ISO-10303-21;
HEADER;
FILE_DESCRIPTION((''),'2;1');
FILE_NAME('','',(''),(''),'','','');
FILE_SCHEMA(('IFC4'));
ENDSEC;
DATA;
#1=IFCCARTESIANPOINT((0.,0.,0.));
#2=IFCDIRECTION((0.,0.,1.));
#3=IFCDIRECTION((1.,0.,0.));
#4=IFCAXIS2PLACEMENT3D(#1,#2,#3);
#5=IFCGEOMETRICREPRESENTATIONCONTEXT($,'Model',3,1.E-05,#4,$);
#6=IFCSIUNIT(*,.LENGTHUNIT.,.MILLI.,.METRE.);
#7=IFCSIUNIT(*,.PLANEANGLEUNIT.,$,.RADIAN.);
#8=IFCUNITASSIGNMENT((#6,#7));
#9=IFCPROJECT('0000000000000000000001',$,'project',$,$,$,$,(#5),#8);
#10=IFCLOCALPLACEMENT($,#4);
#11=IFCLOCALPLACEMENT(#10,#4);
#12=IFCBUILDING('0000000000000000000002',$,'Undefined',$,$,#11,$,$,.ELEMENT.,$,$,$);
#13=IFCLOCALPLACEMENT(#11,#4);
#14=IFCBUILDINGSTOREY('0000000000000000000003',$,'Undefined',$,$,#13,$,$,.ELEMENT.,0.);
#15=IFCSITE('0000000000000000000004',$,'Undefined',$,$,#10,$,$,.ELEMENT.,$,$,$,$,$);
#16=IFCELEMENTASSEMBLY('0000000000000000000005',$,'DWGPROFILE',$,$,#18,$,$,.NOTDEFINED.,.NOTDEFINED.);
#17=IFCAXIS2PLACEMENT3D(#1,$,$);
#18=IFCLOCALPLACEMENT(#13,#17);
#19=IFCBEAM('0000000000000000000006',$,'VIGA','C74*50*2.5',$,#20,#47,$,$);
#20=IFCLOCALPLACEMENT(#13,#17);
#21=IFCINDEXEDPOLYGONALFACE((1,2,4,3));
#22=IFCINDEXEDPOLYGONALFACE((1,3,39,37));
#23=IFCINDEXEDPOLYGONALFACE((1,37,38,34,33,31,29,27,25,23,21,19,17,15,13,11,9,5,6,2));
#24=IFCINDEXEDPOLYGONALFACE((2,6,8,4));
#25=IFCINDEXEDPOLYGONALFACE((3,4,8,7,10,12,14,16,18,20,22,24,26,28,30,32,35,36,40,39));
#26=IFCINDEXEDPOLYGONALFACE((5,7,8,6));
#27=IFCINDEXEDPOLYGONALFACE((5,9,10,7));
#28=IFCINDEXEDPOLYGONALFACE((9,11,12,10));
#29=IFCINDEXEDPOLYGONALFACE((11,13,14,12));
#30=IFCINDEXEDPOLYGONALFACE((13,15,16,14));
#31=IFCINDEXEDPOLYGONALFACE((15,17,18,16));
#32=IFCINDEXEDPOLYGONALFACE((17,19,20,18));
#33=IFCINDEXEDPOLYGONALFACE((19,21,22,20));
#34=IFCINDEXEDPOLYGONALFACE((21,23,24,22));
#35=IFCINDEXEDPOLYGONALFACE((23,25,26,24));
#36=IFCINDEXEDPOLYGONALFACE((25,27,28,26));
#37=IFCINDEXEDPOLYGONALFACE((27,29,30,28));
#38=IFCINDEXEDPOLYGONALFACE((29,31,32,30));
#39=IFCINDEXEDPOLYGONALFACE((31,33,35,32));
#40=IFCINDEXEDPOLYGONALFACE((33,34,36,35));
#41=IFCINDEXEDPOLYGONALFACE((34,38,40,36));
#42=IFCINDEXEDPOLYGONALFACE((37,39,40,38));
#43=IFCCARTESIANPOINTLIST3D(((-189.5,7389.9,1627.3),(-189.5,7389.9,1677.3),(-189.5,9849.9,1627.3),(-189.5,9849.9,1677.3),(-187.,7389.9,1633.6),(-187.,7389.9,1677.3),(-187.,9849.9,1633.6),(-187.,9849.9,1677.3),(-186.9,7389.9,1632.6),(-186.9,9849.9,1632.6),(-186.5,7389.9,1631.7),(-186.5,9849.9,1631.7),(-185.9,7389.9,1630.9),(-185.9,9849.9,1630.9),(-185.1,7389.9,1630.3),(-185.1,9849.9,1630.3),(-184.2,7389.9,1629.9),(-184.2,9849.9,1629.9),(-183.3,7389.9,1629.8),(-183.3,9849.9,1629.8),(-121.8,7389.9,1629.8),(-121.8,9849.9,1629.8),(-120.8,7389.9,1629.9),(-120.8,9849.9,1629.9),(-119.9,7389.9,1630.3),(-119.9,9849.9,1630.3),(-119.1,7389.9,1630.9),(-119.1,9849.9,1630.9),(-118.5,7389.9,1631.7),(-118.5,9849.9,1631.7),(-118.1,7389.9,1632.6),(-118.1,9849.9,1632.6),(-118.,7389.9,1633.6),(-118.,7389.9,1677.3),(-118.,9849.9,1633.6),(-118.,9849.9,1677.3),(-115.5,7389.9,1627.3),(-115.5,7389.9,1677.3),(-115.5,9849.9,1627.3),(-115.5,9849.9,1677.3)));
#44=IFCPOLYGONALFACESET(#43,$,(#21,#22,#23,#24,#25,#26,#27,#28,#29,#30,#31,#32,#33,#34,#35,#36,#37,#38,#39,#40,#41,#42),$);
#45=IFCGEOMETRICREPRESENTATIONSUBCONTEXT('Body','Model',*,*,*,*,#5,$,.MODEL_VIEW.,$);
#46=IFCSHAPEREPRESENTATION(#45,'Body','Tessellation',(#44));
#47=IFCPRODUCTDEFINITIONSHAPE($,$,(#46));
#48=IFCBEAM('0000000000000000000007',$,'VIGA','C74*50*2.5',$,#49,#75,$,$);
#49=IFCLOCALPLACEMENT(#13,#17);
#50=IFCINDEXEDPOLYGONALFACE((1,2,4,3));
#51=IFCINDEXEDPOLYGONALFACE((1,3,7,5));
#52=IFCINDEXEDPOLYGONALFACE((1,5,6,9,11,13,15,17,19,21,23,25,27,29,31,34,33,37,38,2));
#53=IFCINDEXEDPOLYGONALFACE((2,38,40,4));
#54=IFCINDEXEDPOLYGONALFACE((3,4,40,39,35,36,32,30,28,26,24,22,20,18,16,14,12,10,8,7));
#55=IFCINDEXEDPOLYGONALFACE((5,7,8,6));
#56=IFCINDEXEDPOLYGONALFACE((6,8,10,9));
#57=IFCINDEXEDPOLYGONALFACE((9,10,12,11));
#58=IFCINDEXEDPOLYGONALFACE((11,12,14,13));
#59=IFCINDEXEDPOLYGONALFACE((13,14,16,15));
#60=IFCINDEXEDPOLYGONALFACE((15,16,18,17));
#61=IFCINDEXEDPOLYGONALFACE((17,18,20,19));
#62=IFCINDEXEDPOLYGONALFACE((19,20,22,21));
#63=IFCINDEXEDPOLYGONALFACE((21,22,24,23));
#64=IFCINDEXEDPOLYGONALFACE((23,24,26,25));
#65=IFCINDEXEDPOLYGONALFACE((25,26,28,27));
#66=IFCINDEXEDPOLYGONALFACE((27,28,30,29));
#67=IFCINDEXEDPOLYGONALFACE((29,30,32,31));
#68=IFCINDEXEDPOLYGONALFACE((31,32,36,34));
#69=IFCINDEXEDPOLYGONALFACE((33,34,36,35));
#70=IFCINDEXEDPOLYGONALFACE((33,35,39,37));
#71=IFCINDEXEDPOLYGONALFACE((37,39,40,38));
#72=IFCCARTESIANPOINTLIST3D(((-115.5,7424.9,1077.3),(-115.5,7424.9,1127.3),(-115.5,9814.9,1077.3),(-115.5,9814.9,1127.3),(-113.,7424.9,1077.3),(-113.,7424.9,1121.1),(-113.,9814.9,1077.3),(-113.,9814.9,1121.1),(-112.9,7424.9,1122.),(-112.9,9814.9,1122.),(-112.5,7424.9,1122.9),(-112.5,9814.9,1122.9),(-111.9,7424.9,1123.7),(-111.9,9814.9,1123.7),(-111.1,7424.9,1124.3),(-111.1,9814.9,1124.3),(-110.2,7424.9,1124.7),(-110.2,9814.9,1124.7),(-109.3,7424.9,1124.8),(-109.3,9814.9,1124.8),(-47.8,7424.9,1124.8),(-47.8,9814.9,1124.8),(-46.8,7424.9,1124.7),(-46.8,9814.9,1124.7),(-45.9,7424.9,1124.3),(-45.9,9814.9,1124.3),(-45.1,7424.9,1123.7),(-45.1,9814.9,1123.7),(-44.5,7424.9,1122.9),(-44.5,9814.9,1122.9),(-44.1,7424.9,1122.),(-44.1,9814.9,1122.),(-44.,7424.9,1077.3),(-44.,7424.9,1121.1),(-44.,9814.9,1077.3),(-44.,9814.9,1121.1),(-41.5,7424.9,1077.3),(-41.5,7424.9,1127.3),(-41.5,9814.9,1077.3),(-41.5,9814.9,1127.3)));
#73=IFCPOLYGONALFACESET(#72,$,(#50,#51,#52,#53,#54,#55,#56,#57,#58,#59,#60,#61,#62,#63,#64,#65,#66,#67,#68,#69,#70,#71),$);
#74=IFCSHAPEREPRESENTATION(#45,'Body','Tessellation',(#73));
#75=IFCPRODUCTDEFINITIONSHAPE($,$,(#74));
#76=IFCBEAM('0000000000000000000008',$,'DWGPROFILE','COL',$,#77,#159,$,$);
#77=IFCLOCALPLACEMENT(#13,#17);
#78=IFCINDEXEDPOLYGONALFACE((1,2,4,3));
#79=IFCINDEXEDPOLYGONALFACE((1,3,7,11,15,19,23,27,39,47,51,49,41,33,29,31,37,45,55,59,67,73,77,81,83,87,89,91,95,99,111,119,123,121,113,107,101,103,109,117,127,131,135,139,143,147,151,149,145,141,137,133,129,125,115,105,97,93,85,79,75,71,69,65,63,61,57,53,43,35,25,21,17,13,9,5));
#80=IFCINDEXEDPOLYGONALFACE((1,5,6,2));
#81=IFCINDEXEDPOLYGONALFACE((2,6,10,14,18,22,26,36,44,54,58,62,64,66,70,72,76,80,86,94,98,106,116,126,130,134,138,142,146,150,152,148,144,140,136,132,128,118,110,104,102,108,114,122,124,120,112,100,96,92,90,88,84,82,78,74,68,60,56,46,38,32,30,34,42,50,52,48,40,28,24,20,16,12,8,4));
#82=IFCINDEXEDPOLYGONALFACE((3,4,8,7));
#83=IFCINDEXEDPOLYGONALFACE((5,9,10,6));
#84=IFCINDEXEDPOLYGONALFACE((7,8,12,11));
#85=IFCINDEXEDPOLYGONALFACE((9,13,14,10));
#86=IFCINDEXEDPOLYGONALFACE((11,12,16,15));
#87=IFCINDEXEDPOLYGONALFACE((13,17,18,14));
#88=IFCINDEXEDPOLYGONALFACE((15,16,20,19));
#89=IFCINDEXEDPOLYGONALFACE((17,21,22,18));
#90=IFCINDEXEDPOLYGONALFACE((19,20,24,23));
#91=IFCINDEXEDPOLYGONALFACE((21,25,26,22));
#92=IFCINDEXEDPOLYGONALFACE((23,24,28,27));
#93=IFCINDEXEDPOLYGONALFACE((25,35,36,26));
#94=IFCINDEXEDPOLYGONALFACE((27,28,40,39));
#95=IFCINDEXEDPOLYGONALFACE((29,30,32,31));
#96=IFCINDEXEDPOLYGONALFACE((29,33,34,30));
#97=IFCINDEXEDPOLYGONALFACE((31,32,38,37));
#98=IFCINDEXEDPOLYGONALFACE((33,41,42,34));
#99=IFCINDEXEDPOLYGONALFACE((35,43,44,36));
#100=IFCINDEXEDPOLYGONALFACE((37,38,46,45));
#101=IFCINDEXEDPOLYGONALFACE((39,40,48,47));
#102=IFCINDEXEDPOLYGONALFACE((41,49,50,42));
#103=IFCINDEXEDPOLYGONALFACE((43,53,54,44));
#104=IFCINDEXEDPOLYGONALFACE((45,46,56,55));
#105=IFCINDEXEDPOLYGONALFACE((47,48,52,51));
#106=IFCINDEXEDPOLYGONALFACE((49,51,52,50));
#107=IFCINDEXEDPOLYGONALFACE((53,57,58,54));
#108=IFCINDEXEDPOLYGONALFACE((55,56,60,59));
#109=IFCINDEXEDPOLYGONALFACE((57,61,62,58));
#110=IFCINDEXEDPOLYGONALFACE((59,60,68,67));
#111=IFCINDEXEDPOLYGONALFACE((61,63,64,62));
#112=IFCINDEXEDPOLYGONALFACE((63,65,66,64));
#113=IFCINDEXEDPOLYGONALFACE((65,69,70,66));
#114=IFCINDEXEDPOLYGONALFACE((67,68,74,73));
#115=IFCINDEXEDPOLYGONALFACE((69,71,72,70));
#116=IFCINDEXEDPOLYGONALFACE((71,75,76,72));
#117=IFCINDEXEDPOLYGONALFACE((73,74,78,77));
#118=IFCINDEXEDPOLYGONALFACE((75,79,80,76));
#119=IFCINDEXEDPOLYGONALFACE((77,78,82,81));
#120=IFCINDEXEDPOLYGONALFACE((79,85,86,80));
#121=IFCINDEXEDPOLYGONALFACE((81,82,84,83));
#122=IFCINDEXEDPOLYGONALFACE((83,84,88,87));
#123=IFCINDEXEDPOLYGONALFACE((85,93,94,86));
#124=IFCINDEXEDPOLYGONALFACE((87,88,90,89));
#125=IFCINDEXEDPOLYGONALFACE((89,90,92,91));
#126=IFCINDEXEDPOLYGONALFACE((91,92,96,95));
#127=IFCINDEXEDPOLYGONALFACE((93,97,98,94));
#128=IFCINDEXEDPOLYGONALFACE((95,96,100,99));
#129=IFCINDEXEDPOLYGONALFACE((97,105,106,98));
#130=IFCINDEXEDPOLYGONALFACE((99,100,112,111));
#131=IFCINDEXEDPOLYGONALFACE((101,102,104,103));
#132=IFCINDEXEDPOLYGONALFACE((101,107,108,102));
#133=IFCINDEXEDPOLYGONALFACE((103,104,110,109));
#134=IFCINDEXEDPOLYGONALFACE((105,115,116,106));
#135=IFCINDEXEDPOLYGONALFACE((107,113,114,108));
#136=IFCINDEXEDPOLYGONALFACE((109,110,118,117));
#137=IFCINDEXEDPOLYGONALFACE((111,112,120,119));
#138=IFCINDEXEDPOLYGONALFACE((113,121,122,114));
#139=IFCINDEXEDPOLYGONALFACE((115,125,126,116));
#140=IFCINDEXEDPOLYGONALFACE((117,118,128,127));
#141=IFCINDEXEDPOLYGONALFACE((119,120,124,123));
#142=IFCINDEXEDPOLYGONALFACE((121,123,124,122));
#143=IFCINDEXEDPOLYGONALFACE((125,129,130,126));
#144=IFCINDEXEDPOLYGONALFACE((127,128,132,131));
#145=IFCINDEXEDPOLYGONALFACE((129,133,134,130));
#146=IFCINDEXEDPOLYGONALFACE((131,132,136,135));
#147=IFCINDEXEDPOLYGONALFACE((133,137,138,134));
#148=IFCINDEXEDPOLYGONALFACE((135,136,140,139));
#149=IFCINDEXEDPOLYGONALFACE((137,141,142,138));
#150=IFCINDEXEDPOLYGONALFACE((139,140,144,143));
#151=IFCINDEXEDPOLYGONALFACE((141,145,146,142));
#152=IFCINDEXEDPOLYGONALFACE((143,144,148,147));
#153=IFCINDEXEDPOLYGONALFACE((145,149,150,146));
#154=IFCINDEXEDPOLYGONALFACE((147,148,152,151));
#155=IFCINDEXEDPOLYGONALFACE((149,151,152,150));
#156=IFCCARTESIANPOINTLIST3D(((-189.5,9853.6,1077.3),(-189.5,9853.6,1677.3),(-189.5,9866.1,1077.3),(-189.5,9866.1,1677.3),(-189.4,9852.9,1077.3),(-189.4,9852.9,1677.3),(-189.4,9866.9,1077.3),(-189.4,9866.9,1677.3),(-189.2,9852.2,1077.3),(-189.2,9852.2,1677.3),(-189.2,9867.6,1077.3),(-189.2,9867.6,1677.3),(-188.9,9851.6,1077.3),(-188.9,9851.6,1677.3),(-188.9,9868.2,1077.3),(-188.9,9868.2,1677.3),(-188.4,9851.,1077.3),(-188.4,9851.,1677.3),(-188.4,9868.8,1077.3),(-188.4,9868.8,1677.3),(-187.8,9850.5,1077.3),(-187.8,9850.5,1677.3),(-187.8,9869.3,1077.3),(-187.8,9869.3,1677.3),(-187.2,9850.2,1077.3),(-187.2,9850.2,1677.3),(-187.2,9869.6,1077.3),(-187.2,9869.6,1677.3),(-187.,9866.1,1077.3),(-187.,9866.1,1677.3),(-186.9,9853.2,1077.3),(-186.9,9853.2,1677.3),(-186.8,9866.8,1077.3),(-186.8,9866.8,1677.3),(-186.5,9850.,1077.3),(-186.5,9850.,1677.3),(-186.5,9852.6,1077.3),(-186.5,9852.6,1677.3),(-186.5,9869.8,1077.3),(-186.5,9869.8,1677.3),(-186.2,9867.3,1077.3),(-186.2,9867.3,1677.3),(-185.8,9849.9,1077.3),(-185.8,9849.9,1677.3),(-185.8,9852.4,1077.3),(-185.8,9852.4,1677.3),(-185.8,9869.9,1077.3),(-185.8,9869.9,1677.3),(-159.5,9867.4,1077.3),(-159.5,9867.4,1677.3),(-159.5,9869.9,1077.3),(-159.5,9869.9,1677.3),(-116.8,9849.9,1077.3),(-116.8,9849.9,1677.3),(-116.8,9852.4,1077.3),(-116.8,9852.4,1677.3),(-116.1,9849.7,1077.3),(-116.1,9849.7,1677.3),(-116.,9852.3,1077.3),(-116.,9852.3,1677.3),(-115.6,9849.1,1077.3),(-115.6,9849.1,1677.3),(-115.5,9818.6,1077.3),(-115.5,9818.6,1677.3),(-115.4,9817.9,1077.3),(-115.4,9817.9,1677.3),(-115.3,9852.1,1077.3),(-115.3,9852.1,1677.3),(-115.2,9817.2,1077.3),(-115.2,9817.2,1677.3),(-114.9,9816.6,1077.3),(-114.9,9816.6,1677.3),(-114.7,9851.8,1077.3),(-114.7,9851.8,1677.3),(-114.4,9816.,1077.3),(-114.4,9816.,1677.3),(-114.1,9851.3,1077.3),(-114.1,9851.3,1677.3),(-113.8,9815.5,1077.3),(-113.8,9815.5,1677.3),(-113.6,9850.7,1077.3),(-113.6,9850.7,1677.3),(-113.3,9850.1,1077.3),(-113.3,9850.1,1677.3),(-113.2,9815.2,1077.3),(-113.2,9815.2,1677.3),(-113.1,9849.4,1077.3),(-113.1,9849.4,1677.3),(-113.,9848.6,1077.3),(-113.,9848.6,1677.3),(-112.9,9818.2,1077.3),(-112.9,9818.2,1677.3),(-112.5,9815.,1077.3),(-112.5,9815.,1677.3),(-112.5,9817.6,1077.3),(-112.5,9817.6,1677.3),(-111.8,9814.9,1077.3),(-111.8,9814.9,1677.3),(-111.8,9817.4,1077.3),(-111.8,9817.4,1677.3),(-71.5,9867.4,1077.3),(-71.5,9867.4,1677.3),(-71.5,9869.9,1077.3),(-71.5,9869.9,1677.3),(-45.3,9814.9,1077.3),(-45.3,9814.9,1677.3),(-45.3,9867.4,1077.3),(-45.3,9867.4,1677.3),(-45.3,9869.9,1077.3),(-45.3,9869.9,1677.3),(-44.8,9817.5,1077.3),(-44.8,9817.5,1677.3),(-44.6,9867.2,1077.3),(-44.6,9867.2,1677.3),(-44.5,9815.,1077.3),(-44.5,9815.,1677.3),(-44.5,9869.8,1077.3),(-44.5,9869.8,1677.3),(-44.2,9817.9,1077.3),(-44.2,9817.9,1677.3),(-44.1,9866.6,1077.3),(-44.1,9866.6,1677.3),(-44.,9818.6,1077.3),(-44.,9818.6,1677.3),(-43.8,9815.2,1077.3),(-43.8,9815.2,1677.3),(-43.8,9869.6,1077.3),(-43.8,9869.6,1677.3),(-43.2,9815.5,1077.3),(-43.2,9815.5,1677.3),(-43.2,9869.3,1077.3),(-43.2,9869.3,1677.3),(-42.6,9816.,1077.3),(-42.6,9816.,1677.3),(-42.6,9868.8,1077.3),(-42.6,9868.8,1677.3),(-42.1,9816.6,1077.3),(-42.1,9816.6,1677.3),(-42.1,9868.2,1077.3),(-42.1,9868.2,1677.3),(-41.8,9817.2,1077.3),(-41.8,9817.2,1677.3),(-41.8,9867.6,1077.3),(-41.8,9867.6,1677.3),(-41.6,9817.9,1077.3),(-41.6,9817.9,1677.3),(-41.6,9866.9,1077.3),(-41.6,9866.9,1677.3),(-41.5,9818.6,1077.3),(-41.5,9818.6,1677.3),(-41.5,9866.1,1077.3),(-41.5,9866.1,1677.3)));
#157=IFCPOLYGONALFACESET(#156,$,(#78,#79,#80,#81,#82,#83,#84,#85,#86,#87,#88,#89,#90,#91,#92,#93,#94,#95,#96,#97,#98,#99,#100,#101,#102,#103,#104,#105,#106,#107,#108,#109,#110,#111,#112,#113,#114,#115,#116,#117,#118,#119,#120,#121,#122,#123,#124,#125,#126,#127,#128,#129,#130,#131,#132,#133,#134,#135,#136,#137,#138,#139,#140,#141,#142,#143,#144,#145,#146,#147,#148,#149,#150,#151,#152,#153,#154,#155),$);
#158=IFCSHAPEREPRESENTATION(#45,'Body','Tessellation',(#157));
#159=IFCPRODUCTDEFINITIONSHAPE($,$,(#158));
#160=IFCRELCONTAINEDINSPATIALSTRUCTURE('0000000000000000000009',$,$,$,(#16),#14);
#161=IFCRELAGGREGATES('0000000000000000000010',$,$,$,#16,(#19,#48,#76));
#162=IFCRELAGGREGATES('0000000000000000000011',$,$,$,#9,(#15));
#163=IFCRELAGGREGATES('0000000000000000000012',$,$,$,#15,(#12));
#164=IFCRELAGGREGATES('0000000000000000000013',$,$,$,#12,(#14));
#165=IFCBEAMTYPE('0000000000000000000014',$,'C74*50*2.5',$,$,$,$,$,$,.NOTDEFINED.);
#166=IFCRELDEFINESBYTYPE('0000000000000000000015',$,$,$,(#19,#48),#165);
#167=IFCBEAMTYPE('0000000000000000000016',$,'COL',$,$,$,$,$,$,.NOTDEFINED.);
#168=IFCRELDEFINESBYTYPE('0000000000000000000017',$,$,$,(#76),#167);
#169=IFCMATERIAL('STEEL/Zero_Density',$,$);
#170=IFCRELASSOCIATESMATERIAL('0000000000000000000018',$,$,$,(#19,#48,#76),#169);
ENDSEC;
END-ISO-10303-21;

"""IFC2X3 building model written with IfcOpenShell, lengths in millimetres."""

from ifc_helpers import new_model, si_unit, frame, origin_with_axes, origin_2d_with_axis, place, context, subcontext, project, spatial, polyline, u_section, outline, extrude, material, type_object, element, aggregate, save


model = new_model("IFC2X3")

# Units and contexts
model_context = context("Model", 3, precision=1e-05, world=origin_with_axes())
body_context = subcontext(model_context, "Body", "Model", "MODEL_VIEW")
ifc_project = project(units=[si_unit("LENGTHUNIT", "METRE", prefix="MILLI"), si_unit("PLANEANGLEUNIT", "RADIAN")], contexts=[model_context])

# Site, building, storey
site_placement = place(None, origin_with_axes())
site = spatial("IfcSite", under=ifc_project, at=site_placement, Name="Undefined", CompositionType="ELEMENT")
building_placement = place(site_placement, origin_with_axes())
building = spatial("IfcBuilding", under=site, at=building_placement, Name="Undefined", CompositionType="ELEMENT")
storey_placement = place(building_placement, origin_with_axes())
storey = spatial("IfcBuildingStorey", under=building, at=storey_placement, Name="Undefined", CompositionType="ELEMENT", Elevation=0.0)

# Shared definitions
ifc_material_1 = material(Name="STEEL/Zero_Density")

# Element assembly, beams
assembly_1_placement = place(storey_placement, origin_with_axes())
assembly_1 = element("IfcElementAssembly", 1, at=assembly_1_placement, inside=storey, Name="DWGPROFILE", AssemblyPlace="NOTDEFINED", PredefinedType="NOTDEFINED")
beam_type_1 = type_object("IfcBeamType", Name="C74*50*2.5", PredefinedType="NOTDEFINED")
beam_1_placement = place(assembly_1_placement, frame((-152.5, 9849.9, 1652.3), z_axis=(1.0, 0.0, 0.0), x_axis=(0.0, -1.0, 0.0)))
beam_1 = element("IfcBeam", 2, at=beam_1_placement, type_object=beam_type_1, material=ifc_material_1, Name="VIGA", Description="C74*50*2.5", context=body_context, shape_type="SweptSolid", body=[
    extrude(u_section(Depth=74.0, FlangeWidth=50.0, WebThickness=2.5, FlangeThickness=2.5, FilletRadius=3.8, at=origin_2d_with_axis()), frame((2460.0, 0.0, 0.0), z_axis=(-1.0, 0.0, 0.0), x_axis=(0.0, -1.0, 0.0)), (0.0, 0.0, 1.0), 2460.0),
])
beam_2_placement = place(assembly_1_placement, frame((-78.5, 9814.9, 1102.3), z_axis=(-1.0, 0.0, 0.0), x_axis=(0.0, -1.0, 0.0)))
beam_2 = element("IfcBeam", 3, at=beam_2_placement, type_object=beam_type_1, material=ifc_material_1, Name="VIGA", Description="C74*50*2.5", context=body_context, shape_type="SweptSolid", body=[
    extrude(u_section(Depth=74.0, FlangeWidth=50.0, WebThickness=2.5, FlangeThickness=2.5, FilletRadius=3.8, at=origin_2d_with_axis()), frame((2390.0, 0.0, 0.0), z_axis=(-1.0, 0.0, 0.0), x_axis=(0.0, -1.0, 0.0)), (0.0, 0.0, 1.0), 2390.0),
])
beam_type_2 = type_object("IfcBeamType", Name="COL", PredefinedType="NOTDEFINED")
beam_3_placement = place(assembly_1_placement, frame((-115.5, 9842.4, 1677.3), z_axis=(1.0, 0.0, 0.0), x_axis=(0.0, 0.000001, -1.0)))
beam_3 = element("IfcBeam", 4, at=beam_3_placement, type_object=beam_type_2, material=ifc_material_1, Name="DWGPROFILE", Description="COL", context=body_context, shape_type="SweptSolid", body=[
    extrude(outline(polyline([(27.5, 70.2), (27.5, 3.8), (27.4, 3.0), (27.2, 2.3), (26.9, 1.7), (26.4, 1.1), (25.8, 0.6), (25.2, 0.3), (24.5, 0.1), (23.8, 0.0), (-6.7, -0.1), (-7.3, -0.6), (-7.5, -1.2), (-7.5, -70.2), (-7.6, -71.0), (-7.8, -71.7), (-8.1, -72.3), (-8.6, -72.9), (-9.2, -73.4), (-9.8, -73.7), (-10.5, -73.9), (-11.2, -74.0), (-23.8, -74.0), (-24.5, -73.9), (-25.2, -73.7), (-25.8, -73.4), (-26.4, -72.9), (-26.9, -72.3), (-27.2, -71.7), (-27.4, -71.0), (-27.5, -70.2), (-27.5, -44.0), (-25.0, -44.0), (-24.9, -70.7), (-24.4, -71.3), (-23.8, -71.5), (-10.8, -71.4), (-10.2, -70.9), (-10.0, -70.2), (-10.0, -1.2), (-9.9, -0.5), (-9.7, 0.2), (-9.4, 0.8), (-8.9, 1.4), (-8.3, 1.9), (-7.7, 2.2), (-7.0, 2.4), (-6.2, 2.5), (24.2, 2.6), (24.8, 3.1), (25.0, 3.8), (24.9, 70.7), (24.4, 71.3), (23.8, 71.5), (-24.2, 71.4), (-24.8, 70.9), (-25.0, 70.2), (-25.0, 44.0), (-27.5, 44.0), (-27.5, 70.2), (-27.4, 71.0), (-27.2, 71.7), (-26.9, 72.3), (-26.4, 72.9), (-25.8, 73.4), (-25.2, 73.7), (-24.5, 73.9), (-23.8, 74.0), (23.8, 74.0), (24.5, 73.9), (25.2, 73.7), (25.8, 73.4), (26.4, 72.9), (26.9, 72.3), (27.2, 71.7), (27.4, 71.0), (27.5, 70.2)])), frame((600.0, 0.0, 0.0), z_axis=(-1.0, 0.0, 0.0), x_axis=(0.0, -1.0, 0.0)), (0.0, 0.0, 1.0), 600.0),
])

aggregate(assembly_1, [beam_1, beam_2, beam_3])

save(model, "model.ifc")
